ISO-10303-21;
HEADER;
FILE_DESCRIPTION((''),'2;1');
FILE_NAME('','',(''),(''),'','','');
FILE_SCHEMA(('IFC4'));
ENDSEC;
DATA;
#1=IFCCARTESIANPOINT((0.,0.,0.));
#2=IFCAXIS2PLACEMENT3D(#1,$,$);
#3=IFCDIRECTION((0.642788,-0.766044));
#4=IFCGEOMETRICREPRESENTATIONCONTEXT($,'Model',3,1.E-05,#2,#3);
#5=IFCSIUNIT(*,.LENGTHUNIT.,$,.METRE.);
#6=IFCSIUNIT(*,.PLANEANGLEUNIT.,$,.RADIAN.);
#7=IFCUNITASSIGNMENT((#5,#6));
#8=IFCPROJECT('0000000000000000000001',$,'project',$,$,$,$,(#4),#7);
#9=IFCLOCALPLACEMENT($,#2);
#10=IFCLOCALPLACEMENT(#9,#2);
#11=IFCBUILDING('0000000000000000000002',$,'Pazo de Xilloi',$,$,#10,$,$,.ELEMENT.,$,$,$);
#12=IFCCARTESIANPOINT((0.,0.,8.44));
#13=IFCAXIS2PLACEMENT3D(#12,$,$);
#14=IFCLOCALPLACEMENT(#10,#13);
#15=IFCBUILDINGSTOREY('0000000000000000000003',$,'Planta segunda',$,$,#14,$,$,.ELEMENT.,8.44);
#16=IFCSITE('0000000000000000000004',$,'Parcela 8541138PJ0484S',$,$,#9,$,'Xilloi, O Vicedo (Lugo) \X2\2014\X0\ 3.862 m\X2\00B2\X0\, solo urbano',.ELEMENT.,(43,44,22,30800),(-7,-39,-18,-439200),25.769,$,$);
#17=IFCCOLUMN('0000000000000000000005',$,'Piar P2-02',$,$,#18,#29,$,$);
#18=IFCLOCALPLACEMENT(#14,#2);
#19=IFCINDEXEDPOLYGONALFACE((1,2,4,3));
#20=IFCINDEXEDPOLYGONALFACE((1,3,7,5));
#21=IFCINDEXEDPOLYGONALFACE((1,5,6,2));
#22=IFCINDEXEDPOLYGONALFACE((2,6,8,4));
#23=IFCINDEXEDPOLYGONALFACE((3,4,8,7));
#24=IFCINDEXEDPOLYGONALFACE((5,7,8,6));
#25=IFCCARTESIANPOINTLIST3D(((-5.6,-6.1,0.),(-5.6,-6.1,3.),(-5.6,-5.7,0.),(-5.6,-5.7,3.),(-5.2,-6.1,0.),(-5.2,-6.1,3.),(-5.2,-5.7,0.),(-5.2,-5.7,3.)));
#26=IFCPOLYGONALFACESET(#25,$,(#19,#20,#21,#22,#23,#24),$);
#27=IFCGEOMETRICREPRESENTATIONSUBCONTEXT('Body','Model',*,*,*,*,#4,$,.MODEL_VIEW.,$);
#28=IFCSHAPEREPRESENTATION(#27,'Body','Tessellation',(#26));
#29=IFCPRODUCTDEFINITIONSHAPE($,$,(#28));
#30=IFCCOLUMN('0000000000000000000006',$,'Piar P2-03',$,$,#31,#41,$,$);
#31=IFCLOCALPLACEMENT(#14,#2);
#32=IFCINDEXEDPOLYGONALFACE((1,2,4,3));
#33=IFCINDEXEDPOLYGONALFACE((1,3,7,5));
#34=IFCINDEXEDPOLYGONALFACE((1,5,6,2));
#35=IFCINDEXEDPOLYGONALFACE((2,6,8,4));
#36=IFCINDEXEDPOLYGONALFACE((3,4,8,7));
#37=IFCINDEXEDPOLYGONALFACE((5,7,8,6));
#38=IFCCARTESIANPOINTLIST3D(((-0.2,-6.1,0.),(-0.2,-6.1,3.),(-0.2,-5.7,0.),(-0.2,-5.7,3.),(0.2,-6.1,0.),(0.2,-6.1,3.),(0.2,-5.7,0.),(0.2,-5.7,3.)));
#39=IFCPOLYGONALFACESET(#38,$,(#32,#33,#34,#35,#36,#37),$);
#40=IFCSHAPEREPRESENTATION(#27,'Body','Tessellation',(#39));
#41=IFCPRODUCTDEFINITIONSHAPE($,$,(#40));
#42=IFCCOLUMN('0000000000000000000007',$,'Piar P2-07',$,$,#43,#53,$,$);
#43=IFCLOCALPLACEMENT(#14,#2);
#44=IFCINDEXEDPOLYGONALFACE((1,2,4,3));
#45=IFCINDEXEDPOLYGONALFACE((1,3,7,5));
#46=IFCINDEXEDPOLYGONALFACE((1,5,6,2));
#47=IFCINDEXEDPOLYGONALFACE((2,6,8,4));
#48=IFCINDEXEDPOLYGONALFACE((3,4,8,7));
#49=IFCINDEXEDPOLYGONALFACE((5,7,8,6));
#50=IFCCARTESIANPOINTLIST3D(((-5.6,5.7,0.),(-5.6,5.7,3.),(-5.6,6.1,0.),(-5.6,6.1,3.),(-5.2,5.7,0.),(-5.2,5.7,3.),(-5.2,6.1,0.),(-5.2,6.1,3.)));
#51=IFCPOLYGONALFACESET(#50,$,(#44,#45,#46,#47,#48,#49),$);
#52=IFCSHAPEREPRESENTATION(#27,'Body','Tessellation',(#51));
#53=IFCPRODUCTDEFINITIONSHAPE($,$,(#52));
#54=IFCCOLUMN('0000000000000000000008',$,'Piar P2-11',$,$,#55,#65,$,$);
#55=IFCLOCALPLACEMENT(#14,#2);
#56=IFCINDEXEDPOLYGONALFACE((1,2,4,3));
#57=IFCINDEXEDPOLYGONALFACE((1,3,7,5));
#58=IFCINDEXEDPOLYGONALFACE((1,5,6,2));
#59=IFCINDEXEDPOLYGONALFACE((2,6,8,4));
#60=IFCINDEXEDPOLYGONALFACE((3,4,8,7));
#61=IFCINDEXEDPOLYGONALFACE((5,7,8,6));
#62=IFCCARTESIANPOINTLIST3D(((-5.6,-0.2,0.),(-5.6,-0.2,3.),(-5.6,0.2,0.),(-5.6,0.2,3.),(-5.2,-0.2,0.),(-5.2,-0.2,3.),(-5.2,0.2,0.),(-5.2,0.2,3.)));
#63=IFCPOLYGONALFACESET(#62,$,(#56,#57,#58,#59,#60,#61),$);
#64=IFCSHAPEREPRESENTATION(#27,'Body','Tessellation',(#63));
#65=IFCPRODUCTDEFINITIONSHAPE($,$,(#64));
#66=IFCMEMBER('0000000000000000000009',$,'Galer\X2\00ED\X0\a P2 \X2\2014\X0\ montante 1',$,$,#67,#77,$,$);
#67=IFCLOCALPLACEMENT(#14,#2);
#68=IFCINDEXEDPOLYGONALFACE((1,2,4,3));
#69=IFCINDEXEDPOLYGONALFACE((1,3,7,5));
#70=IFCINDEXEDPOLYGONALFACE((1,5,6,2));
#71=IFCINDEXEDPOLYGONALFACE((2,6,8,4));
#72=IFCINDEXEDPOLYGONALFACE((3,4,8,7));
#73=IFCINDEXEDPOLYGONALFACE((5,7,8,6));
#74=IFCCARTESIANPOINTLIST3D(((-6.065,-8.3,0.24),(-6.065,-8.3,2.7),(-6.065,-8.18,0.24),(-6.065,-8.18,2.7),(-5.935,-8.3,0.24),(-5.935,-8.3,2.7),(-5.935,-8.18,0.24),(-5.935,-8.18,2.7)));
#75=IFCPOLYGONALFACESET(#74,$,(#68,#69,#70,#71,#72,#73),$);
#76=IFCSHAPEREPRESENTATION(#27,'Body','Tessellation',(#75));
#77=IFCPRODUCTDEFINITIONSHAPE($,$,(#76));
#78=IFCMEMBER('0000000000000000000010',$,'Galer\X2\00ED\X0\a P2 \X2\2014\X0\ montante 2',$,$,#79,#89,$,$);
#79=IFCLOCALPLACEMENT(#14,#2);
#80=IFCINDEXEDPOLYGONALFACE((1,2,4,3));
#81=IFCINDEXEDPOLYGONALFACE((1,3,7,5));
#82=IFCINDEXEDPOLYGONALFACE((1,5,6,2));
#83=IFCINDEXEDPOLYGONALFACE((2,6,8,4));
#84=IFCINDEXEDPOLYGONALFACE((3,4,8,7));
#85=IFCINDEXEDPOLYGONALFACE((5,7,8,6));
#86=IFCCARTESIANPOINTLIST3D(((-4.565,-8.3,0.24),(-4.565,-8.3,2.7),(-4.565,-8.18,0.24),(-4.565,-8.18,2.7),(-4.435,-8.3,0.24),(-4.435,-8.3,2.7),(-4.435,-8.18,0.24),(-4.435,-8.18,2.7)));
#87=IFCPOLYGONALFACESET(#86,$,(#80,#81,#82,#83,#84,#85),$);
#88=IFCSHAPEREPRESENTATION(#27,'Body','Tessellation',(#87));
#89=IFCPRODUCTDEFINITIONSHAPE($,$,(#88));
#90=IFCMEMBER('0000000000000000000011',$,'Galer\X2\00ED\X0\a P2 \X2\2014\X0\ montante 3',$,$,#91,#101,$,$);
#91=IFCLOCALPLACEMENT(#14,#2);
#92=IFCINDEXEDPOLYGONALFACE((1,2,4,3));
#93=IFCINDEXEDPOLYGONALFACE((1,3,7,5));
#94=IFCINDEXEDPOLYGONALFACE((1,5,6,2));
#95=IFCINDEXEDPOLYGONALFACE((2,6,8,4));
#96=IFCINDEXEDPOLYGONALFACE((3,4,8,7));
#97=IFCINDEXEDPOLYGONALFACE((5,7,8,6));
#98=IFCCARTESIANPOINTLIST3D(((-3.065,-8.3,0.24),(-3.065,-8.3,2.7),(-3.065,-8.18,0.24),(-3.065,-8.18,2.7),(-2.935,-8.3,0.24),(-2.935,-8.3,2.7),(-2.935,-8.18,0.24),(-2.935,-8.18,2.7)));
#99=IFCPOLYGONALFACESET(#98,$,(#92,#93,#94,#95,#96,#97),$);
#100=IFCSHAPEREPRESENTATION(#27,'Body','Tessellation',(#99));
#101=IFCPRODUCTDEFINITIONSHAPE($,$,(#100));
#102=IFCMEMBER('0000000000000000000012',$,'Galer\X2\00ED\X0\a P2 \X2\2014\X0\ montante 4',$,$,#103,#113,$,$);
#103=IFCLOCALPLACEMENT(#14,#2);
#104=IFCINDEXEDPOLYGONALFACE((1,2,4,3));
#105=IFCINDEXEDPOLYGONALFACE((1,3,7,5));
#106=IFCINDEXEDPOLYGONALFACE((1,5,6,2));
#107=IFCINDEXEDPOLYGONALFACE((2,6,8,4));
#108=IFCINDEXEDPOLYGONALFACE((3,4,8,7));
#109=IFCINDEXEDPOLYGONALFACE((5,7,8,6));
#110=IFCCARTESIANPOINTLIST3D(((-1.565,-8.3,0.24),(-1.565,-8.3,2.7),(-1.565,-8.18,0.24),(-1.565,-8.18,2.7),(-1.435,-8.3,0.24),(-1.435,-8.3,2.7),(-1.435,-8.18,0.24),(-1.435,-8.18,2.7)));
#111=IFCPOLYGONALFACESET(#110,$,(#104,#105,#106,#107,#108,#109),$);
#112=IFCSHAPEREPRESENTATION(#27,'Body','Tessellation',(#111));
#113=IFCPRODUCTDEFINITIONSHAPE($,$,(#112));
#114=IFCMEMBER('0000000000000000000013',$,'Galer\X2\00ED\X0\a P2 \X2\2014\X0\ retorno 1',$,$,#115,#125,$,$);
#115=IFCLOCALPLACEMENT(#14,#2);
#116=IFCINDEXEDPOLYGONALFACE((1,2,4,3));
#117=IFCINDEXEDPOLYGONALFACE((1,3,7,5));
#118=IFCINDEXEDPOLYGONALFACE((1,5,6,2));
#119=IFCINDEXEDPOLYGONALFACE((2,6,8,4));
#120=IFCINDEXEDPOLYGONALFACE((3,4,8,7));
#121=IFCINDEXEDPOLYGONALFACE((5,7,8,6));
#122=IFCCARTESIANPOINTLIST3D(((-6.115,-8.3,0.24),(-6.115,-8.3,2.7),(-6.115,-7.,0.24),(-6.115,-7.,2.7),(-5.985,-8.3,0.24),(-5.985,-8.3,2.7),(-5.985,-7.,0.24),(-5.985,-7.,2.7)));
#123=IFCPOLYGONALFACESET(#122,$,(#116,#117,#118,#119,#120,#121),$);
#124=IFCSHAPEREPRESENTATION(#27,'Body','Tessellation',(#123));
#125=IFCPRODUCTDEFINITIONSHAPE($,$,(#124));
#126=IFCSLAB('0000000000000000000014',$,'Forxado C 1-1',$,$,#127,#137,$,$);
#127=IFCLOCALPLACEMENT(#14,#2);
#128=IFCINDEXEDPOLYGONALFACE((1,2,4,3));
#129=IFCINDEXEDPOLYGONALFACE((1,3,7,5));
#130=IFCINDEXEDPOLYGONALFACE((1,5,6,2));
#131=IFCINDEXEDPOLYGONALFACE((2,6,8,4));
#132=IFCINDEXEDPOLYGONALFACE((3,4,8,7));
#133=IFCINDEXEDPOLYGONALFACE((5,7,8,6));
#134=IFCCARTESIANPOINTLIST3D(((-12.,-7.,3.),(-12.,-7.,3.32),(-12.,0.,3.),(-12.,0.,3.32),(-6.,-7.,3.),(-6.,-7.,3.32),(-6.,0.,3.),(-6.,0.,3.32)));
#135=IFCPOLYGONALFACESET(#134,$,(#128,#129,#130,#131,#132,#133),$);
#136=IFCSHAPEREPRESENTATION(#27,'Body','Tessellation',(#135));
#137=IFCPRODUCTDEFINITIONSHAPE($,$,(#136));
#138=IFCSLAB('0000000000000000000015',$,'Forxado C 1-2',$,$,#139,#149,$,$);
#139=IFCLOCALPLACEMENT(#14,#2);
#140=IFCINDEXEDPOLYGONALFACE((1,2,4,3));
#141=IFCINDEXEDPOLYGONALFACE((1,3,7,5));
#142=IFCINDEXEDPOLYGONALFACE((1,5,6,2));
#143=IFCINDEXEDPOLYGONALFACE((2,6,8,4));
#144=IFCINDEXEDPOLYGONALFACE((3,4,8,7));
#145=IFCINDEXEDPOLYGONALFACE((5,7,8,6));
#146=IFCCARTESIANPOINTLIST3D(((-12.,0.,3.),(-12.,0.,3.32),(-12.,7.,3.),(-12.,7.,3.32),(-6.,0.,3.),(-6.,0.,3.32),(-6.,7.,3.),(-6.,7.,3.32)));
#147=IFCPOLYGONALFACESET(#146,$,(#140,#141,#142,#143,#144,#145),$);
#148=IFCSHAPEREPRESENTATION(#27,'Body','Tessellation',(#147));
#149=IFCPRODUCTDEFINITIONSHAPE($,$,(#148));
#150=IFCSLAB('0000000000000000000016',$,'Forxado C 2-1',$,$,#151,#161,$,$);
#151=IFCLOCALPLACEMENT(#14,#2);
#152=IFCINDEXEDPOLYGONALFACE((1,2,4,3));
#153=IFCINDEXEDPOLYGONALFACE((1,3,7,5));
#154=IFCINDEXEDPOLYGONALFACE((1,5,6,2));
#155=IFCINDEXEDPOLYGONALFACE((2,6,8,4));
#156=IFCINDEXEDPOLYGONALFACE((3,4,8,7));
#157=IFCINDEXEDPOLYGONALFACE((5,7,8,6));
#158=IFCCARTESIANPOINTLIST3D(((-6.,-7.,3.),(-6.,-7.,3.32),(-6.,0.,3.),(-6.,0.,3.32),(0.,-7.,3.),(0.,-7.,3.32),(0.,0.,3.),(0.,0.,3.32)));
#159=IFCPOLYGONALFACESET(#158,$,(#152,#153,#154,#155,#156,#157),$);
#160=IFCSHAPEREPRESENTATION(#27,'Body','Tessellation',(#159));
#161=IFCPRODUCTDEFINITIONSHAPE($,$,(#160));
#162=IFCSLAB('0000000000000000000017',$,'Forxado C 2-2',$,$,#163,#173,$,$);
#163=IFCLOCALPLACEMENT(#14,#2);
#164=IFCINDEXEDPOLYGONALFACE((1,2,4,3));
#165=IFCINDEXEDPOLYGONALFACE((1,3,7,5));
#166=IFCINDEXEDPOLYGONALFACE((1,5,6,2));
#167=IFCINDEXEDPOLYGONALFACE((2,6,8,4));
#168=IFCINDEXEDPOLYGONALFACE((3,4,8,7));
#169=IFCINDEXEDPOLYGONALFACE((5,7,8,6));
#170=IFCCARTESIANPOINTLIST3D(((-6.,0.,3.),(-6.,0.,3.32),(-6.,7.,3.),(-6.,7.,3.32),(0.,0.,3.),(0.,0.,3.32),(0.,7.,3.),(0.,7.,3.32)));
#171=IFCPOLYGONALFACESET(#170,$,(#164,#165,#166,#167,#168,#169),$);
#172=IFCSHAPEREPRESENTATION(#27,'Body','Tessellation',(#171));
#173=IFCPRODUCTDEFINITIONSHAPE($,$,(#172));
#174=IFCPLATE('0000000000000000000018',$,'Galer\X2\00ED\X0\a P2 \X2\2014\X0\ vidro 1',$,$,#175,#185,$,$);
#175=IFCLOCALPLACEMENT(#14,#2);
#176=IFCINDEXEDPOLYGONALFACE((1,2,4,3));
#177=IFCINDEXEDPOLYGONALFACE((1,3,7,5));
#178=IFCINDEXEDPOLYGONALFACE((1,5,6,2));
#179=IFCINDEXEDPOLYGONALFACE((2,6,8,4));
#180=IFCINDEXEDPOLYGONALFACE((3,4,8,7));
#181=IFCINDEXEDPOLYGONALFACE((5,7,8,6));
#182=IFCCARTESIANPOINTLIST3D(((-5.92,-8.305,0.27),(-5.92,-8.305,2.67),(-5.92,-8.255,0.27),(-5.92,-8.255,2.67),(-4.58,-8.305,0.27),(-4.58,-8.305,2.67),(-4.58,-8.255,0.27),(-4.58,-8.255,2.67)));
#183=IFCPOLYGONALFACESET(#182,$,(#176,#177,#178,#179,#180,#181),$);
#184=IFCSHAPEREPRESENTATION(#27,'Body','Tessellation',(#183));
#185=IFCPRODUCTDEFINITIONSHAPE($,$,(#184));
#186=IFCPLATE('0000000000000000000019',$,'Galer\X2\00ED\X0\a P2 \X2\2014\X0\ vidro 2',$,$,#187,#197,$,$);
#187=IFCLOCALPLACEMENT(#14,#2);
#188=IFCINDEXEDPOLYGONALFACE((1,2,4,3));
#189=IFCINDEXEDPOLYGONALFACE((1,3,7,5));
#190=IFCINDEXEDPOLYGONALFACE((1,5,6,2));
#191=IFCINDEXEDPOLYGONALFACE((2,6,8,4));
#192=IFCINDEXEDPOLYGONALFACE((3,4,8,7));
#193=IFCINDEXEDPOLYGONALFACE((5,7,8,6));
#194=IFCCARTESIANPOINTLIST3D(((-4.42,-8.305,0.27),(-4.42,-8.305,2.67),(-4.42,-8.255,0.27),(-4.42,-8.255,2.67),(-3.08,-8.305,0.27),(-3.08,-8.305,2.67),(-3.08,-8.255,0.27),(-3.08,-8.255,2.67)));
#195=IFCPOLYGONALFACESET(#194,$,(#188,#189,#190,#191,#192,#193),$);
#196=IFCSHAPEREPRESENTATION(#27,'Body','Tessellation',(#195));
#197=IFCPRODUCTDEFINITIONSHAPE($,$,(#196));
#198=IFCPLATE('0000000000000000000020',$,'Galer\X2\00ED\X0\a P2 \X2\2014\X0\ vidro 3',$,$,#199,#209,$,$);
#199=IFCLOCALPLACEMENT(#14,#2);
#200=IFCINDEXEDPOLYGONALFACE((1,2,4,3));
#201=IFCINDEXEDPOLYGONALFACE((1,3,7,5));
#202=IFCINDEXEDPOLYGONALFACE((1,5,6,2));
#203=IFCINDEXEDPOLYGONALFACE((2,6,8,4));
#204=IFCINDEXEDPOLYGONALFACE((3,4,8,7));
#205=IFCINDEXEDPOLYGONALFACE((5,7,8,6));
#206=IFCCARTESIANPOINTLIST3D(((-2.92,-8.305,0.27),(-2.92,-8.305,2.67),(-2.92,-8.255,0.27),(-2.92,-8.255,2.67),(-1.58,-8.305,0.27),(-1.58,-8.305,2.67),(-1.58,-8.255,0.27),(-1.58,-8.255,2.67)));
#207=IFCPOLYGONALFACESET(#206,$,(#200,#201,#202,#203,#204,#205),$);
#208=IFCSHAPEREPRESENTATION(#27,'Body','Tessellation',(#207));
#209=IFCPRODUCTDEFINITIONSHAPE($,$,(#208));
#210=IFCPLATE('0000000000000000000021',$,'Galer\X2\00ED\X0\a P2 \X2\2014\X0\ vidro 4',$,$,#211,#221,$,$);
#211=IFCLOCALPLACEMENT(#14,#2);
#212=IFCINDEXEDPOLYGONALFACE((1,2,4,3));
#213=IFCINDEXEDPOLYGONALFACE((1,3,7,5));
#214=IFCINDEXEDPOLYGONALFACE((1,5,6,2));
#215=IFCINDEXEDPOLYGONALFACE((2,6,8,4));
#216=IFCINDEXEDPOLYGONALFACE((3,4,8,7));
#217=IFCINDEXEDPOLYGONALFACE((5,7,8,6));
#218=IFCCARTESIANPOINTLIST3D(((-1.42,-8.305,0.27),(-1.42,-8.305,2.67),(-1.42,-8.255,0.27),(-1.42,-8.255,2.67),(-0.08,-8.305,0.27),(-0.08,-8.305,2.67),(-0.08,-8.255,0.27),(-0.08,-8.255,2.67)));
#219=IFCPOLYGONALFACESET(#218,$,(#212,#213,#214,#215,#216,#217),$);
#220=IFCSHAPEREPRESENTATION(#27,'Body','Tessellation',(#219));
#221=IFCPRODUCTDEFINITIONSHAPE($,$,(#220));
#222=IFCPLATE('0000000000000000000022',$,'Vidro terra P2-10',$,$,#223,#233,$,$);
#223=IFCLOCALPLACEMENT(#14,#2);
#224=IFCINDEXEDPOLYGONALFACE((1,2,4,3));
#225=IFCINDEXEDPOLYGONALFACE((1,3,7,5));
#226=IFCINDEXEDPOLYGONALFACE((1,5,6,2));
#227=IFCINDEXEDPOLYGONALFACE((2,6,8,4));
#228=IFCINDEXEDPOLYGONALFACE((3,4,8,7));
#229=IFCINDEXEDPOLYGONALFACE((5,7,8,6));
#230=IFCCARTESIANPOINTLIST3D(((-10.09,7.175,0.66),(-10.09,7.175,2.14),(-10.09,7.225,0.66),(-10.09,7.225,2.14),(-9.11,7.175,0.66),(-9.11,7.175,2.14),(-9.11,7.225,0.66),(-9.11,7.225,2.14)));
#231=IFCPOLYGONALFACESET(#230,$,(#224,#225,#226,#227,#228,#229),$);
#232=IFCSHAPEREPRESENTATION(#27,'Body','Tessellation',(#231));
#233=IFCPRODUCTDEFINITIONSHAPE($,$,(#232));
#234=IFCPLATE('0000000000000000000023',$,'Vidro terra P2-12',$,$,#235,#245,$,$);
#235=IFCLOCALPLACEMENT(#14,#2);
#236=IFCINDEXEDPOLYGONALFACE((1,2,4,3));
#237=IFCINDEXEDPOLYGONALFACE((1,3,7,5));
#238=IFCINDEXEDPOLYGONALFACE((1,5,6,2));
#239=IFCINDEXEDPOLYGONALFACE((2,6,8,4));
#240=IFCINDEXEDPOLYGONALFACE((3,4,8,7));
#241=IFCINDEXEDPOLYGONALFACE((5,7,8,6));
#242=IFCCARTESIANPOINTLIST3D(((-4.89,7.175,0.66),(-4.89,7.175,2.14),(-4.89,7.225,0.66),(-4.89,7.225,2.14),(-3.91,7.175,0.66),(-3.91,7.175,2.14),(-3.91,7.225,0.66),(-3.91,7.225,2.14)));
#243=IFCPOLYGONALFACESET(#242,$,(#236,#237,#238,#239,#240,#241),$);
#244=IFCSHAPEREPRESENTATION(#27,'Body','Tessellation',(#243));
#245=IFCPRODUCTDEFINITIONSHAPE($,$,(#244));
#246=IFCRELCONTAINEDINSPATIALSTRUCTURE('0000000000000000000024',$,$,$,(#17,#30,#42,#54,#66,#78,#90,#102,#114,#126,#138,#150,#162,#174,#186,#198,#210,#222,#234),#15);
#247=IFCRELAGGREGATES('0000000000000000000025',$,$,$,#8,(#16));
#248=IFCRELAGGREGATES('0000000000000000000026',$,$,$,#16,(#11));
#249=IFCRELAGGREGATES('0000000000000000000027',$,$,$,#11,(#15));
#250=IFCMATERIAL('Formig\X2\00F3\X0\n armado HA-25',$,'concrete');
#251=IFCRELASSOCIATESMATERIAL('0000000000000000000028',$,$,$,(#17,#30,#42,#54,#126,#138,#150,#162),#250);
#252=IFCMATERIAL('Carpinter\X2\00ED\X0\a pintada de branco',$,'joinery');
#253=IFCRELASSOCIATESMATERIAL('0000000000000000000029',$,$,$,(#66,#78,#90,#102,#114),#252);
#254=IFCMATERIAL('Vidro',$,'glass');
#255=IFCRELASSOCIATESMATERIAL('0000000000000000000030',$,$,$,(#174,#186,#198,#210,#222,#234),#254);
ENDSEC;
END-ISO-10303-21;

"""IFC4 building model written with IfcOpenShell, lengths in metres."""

from ifc_helpers import new_model, si_unit, direction, frame, origin, origin_2d, place, context, subcontext, project, spatial, rectangle, extrude, material, element, save


model = new_model("IFC4")

# Units and contexts
model_context = context("Model", 3, precision=1e-05, world=origin(), true_north=direction((0.642788, -0.766044)))
body_context = subcontext(model_context, "Body", "Model", "MODEL_VIEW")
ifc_project = project(units=[si_unit("LENGTHUNIT", "METRE"), si_unit("PLANEANGLEUNIT", "RADIAN")], contexts=[model_context])

# Site, building, storey
site_placement = place(None, origin())
site = spatial("IfcSite", under=ifc_project, at=site_placement, Name="Parcela 8541138PJ0484S", LongName="Xilloi, O Vicedo (Lugo) — 3.862 m², solo urbano", CompositionType="ELEMENT", RefLatitude=(43, 44, 22, 30800), RefLongitude=(-7, -39, -18, -439200), RefElevation=25.769)
building_placement = place(site_placement, origin())
building = spatial("IfcBuilding", under=site, at=building_placement, Name="Pazo de Xilloi", CompositionType="ELEMENT")
storey_placement = place(building_placement, frame((0.0, 0.0, 8.44)))
storey = spatial("IfcBuildingStorey", under=building, at=storey_placement, Name="Planta segunda", CompositionType="ELEMENT", Elevation=8.44)

# Columns
ifc_material_1 = material(Name="Formigón armado HA-25", Category="concrete")
for number, where, name in (
    (1, (-5.4, -5.9, 1.5), "Piar P2-02"),
    (2, (0.0, -5.9, 1.5), "Piar P2-03"),
    (3, (-5.4, 5.9, 1.5), "Piar P2-07"),
    (4, (-5.4, 0.0, 1.5), "Piar P2-11"),
):
    element("IfcColumn", number, at=place(storey_placement, frame(where)), inside=storey, material=ifc_material_1, Name=name, context=body_context, shape_type="SweptSolid", body=[
        extrude(rectangle(XDim=0.4, YDim=0.4, at=origin_2d()), frame((0.0, 0.0, -1.5)), (0.0, 0.0, 1.0), 3.0),
    ])

# Members
ifc_material_2 = material(Name="Carpintería pintada de branco", Category="joinery")
for number, where, name in (
    (5, (-6.0, -8.24, 1.47), "Galería P2 — montante 1"),
    (6, (-4.5, -8.24, 1.47), "Galería P2 — montante 2"),
    (7, (-3.0, -8.24, 1.47), "Galería P2 — montante 3"),
    (8, (-1.5, -8.24, 1.47), "Galería P2 — montante 4"),
):
    element("IfcMember", number, at=place(storey_placement, frame(where)), inside=storey, material=ifc_material_2, Name=name, context=body_context, shape_type="SweptSolid", body=[
        extrude(rectangle(XDim=0.13, YDim=0.12, at=origin_2d()), frame((0.0, 0.0, -1.23)), (0.0, 0.0, 1.0), 2.46),
    ])
member_placement = place(storey_placement, frame((-6.05, -7.65, 1.47)))
element("IfcMember", 9, at=member_placement, inside=storey, material=ifc_material_2, Name="Galería P2 — retorno 1", context=body_context, shape_type="SweptSolid", body=[
    extrude(rectangle(XDim=0.13, YDim=1.3, at=origin_2d()), frame((0.0, 0.0, -1.23)), (0.0, 0.0, 1.0), 2.46),
])

# Slabs
for number, where, name in (
    (10, (-9.0, -3.5, 3.16), "Forxado C 1-1"),
    (11, (-9.0, 3.5, 3.16), "Forxado C 1-2"),
    (12, (-3.0, -3.5, 3.16), "Forxado C 2-1"),
    (13, (-3.0, 3.5, 3.16), "Forxado C 2-2"),
):
    element("IfcSlab", number, at=place(storey_placement, frame(where)), inside=storey, material=ifc_material_1, Name=name, context=body_context, shape_type="SweptSolid", body=[
        extrude(rectangle(XDim=6.0, YDim=7.0, at=origin_2d()), frame((0.0, 0.0, -0.16)), (0.0, 0.0, 1.0), 0.32),
    ])

# Plates
ifc_material_3 = material(Name="Vidro", Category="glass")
for number, where, name in (
    (14, (-5.25, -8.28, 1.47), "Galería P2 — vidro 1"),
    (15, (-3.75, -8.28, 1.47), "Galería P2 — vidro 2"),
    (16, (-2.25, -8.28, 1.47), "Galería P2 — vidro 3"),
    (17, (-0.75, -8.28, 1.47), "Galería P2 — vidro 4"),
):
    element("IfcPlate", number, at=place(storey_placement, frame(where)), inside=storey, material=ifc_material_3, Name=name, context=body_context, shape_type="SweptSolid", body=[
        extrude(rectangle(XDim=1.34, YDim=0.05, at=origin_2d()), frame((0.0, 0.0, -1.2)), (0.0, 0.0, 1.0), 2.4),
    ])
for number, where, name in (
    (18, (-9.6, 7.2, 1.4), "Vidro terra P2-10"),
    (19, (-4.4, 7.2, 1.4), "Vidro terra P2-12"),
):
    element("IfcPlate", number, at=place(storey_placement, frame(where)), inside=storey, material=ifc_material_3, Name=name, context=body_context, shape_type="SweptSolid", body=[
        extrude(rectangle(XDim=0.98, YDim=0.05, at=origin_2d()), frame((0.0, 0.0, -0.74)), (0.0, 0.0, 1.0), 1.48),
    ])

save(model, "model.ifc")
